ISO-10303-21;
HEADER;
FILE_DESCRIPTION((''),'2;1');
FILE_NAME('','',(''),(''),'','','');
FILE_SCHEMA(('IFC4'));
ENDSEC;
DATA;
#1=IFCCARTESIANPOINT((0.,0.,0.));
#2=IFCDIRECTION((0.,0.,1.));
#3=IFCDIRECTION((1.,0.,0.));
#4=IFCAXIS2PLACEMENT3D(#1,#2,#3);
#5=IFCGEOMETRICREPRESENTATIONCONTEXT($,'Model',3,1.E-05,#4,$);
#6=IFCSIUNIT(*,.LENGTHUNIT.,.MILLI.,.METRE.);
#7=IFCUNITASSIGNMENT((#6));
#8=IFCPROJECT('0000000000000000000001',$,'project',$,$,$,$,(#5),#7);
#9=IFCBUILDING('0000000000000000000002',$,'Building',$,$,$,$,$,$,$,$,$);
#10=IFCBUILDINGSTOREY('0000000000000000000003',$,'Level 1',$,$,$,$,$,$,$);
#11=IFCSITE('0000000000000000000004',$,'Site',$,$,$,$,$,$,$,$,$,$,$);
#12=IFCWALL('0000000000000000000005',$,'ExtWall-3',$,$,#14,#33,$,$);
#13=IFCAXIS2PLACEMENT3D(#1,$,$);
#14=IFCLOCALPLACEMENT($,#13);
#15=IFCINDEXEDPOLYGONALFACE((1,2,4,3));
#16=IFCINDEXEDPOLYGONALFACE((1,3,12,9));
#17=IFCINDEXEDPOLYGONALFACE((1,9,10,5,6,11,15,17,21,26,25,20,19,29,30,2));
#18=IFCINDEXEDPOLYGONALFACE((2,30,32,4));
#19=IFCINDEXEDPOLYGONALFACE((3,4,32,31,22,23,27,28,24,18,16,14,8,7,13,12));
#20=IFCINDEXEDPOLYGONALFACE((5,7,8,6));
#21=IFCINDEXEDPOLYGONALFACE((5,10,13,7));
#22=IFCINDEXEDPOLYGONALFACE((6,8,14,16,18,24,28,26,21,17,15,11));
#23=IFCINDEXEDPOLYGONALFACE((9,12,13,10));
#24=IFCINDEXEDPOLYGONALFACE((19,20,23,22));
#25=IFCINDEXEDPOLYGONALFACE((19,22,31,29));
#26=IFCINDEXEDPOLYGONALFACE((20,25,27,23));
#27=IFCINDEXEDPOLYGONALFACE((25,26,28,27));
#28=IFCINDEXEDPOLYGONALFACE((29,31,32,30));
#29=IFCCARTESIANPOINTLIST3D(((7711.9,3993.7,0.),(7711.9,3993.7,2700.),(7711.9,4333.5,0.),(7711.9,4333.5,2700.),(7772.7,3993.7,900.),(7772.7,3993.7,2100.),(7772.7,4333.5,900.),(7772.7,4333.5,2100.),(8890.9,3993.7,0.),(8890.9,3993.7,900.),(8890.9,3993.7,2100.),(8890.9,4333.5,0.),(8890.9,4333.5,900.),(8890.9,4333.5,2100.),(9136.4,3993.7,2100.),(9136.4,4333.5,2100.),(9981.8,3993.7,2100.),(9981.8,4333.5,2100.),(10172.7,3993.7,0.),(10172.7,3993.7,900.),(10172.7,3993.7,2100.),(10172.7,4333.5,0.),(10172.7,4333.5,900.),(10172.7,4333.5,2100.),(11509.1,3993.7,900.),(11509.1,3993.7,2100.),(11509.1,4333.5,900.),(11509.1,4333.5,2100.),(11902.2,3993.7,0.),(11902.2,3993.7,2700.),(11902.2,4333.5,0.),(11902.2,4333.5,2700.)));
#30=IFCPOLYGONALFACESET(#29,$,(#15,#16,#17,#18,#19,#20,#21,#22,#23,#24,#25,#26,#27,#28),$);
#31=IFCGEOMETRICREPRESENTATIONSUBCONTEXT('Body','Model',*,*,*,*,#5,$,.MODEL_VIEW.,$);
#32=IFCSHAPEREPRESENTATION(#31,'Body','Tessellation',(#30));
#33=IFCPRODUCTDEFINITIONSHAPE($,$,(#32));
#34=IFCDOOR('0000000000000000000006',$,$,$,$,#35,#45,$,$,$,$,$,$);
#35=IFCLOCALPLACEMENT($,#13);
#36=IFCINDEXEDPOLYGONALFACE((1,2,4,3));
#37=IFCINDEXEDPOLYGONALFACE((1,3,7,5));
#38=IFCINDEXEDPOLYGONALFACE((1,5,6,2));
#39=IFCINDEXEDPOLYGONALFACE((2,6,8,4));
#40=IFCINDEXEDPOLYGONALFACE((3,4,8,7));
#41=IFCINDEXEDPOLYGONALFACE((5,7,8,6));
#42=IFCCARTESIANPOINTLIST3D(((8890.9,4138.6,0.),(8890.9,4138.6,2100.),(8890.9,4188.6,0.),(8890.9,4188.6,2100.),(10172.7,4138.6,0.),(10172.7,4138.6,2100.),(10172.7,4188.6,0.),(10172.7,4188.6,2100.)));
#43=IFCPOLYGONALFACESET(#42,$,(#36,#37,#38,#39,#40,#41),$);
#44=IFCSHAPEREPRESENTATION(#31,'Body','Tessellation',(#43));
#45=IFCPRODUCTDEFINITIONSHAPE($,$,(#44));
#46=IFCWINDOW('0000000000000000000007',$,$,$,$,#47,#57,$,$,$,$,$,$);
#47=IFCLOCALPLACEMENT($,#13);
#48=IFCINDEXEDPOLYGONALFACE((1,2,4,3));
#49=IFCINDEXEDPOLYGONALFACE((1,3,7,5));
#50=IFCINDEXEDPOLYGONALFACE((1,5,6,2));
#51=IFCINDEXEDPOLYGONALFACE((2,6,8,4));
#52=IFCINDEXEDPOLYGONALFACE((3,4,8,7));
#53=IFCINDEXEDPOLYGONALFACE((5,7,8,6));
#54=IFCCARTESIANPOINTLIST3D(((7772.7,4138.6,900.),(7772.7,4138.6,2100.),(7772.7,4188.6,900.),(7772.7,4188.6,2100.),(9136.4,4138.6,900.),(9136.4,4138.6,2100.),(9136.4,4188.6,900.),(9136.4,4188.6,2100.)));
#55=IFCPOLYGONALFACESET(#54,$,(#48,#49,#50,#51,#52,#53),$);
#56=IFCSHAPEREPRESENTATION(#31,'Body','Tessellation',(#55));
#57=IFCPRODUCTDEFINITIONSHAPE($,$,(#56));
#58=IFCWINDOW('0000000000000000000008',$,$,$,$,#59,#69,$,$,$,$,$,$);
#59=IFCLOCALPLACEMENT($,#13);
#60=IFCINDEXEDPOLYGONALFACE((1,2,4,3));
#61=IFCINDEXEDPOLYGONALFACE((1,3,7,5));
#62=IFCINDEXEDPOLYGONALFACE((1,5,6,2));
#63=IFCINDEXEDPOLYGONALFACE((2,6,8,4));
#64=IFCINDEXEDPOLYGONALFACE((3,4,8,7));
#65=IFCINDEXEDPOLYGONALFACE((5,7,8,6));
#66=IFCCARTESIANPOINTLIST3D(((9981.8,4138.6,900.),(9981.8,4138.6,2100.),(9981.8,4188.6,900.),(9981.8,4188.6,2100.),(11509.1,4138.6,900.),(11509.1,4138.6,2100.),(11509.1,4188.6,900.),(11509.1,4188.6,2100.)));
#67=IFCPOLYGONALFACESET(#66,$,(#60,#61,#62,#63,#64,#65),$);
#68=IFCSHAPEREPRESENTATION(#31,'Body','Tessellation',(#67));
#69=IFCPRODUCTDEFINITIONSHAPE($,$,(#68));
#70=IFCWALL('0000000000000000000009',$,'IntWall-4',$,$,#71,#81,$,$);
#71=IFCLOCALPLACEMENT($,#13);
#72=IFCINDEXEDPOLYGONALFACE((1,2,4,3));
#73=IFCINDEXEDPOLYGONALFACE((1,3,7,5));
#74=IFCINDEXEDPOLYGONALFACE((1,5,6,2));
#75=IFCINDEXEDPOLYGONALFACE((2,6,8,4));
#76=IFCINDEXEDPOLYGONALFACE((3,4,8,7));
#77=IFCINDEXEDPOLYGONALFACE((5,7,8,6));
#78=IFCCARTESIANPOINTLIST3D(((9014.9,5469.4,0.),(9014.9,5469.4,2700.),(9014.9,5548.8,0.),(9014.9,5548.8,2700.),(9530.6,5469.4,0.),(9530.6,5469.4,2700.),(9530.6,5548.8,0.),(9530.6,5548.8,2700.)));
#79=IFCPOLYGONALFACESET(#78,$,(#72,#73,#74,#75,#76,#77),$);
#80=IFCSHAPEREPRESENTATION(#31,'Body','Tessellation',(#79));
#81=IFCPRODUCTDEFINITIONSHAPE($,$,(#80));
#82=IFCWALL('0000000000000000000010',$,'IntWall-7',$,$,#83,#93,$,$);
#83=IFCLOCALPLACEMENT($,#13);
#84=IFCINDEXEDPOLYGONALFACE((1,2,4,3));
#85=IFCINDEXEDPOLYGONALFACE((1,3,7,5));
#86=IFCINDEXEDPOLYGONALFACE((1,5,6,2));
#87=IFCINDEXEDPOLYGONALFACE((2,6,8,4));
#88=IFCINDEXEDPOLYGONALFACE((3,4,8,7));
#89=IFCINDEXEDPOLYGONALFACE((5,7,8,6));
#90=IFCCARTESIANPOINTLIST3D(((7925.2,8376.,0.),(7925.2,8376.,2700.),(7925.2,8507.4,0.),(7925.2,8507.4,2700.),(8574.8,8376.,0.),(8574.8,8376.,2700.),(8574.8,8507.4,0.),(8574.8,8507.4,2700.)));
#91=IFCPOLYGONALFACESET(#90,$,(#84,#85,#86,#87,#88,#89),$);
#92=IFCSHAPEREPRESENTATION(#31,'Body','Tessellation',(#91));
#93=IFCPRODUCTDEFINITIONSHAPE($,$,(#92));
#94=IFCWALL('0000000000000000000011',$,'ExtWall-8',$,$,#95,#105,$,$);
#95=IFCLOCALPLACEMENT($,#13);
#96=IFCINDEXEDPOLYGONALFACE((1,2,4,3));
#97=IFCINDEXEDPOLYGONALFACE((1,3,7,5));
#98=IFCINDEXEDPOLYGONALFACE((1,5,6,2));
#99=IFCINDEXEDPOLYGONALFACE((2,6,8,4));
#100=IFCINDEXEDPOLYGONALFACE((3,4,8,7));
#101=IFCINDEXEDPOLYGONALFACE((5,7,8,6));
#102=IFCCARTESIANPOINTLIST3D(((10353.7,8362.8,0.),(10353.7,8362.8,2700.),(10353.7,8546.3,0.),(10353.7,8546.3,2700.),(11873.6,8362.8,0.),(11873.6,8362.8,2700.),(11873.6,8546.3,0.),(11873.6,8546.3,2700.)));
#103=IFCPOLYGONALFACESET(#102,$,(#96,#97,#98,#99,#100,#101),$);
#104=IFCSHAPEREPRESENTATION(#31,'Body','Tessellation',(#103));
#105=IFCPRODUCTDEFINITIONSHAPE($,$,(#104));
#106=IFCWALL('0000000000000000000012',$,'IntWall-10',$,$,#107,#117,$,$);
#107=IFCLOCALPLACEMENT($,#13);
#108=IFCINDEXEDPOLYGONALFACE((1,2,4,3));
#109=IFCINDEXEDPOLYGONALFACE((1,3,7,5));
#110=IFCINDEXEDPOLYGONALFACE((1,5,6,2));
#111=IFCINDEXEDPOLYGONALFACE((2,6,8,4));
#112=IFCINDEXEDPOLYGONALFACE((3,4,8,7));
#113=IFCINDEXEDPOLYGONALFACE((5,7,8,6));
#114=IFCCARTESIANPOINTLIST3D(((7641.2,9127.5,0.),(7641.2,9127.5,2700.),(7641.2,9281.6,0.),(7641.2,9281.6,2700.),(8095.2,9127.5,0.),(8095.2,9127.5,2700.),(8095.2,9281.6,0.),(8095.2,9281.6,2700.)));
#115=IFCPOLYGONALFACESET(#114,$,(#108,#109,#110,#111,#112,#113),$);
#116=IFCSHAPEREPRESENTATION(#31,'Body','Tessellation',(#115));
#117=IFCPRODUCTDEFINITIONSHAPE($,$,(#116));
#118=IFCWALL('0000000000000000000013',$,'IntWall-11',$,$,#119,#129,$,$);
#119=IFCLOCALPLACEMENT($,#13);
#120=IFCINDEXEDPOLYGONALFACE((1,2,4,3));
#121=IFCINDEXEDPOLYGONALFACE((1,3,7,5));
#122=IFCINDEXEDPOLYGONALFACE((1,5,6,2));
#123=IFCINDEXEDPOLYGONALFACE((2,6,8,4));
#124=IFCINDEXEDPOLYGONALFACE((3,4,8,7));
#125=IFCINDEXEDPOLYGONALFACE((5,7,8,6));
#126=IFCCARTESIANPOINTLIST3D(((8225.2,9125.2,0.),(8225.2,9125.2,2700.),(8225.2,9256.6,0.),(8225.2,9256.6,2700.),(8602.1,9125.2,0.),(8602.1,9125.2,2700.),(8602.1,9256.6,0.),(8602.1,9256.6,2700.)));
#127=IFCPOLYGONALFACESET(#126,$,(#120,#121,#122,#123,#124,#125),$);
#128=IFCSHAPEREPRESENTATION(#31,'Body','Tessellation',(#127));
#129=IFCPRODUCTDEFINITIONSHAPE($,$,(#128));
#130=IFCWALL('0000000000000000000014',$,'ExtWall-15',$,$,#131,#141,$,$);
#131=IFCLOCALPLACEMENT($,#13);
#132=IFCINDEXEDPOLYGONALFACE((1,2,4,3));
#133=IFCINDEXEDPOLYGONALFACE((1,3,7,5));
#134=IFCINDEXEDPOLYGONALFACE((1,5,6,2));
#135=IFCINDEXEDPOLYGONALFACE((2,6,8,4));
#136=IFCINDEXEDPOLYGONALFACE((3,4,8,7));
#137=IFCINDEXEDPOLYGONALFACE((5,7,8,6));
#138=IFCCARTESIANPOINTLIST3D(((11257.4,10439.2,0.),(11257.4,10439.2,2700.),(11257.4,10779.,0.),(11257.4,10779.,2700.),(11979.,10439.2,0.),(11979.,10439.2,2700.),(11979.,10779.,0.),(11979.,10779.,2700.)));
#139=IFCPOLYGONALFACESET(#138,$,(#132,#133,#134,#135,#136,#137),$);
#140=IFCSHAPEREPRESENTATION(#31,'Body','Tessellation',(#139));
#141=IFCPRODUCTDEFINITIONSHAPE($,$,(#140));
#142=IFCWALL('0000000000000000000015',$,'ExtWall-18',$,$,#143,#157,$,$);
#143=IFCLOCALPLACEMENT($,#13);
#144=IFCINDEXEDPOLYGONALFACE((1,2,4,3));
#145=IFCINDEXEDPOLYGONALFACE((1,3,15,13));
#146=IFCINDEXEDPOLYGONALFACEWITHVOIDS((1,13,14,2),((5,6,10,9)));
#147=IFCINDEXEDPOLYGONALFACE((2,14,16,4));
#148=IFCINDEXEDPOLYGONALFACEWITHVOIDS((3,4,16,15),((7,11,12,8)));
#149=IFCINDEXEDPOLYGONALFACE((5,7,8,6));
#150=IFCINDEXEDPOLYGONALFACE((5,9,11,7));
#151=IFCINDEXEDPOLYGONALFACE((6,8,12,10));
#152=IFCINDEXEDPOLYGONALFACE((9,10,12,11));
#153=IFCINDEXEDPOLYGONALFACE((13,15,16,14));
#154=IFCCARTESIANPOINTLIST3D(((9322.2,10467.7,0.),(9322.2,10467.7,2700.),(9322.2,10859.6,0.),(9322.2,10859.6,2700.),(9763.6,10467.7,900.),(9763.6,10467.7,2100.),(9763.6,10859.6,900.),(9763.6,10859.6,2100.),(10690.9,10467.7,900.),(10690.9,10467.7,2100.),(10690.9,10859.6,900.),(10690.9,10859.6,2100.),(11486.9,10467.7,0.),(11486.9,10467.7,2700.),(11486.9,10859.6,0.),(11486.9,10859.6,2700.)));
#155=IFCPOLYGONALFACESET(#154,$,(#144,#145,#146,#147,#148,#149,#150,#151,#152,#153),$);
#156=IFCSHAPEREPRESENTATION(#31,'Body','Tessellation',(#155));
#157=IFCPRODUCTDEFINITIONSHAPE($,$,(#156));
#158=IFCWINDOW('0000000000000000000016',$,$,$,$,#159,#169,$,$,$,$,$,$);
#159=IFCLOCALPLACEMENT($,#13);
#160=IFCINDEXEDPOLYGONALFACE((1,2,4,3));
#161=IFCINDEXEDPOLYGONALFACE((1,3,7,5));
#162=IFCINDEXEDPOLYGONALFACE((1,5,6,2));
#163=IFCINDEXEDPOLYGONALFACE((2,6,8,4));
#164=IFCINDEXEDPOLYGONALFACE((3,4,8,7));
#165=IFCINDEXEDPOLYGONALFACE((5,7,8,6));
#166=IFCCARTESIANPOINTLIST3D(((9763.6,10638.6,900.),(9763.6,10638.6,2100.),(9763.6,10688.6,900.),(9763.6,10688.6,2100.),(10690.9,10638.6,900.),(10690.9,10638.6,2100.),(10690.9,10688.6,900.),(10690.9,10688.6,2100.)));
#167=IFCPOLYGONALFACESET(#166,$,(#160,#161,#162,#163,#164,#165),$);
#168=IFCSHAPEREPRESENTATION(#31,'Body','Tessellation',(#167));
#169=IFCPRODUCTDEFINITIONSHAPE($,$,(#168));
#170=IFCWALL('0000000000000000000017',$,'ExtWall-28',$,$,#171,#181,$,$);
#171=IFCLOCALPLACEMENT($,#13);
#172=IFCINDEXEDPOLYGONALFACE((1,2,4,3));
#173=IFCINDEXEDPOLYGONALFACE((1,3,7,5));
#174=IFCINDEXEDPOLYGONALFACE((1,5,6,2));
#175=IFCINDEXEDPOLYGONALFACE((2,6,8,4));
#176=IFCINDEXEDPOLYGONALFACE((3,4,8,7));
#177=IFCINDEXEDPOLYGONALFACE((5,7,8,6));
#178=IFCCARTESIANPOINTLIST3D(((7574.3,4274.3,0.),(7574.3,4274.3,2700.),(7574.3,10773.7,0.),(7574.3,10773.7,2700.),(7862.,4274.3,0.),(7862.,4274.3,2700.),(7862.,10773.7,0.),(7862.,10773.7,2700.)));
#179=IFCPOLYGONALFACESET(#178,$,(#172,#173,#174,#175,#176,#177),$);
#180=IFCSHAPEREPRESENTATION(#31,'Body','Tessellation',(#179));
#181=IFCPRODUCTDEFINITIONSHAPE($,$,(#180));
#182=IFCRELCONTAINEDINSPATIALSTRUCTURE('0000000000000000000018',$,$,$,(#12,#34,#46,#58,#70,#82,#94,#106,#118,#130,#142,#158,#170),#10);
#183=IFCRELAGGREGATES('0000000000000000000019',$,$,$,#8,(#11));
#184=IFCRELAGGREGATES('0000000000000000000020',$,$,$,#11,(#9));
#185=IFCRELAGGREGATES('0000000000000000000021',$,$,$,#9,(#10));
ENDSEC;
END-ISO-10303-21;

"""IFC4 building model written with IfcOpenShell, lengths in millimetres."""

from ifc_helpers import new_model, si_unit, frame, origin_with_axes, place, context, subcontext, project, spatial, indexed_curve, outline, extrude, element, fill, save


model = new_model("IFC4")

# Units and contexts
model_context = context("Model", 3, precision=1e-05, world=origin_with_axes())
body_context = subcontext(model_context, "Body", "Model", "MODEL_VIEW")
ifc_project = project(units=[si_unit("LENGTHUNIT", "METRE", prefix="MILLI")], contexts=[model_context])

# Site, building, storey
site = spatial("IfcSite", under=ifc_project, Name="Site")
building = spatial("IfcBuilding", under=site, Name="Building")
storey = spatial("IfcBuildingStorey", under=building, Name="Level 1")

# Wall, openings, door, windows
wall_1_placement = place(None, frame((7711.9, 4163.6, 0.0), z_axis=(0.0, 0.0, 1.0), x_axis=(1.0, 0.0, 0.0)))
wall_1 = element("IfcWall", 1, at=wall_1_placement, inside=storey, Name="ExtWall-3", context=body_context, shape_type="SweptSolid", body=[
    extrude(outline(indexed_curve([(0.0, 0.0), (0.0, 339.8), (4190.3, 339.8), (4190.3, 0.0), (0.0, 0.0)], self_intersect=False)), frame((0.0, -169.9, 0.0), z_axis=(0.0, 0.0, 1.0), x_axis=(1.0, 0.0, 0.0)), (0.0, 0.0, 1.0), 2700.0),
])
opening_1_placement = place(wall_1_placement, frame((1179.0, 0.0, 0.0), z_axis=(0.0, 0.0, 1.0), x_axis=(1.0, 0.0, 0.0)))
opening_1 = element("IfcOpeningElement", 2, at=opening_1_placement, cuts=wall_1, context=body_context, shape_type="SweptSolid", body=[
    extrude(outline(indexed_curve([(0.0, 0.0), (0.0, 439.8), (1281.8, 439.8), (1281.8, 0.0), (0.0, 0.0)], self_intersect=False)), frame((0.0, -219.9, 0.0), z_axis=(0.0, 0.0, 1.0), x_axis=(1.0, 0.0, 0.0)), (0.0, 0.0, 1.0), 2100.0),
])
opening_2_placement = place(wall_1_placement, frame((60.8, 0.0, 900.0), z_axis=(0.0, 0.0, 1.0), x_axis=(1.0, 0.0, 0.0)))
opening_2 = element("IfcOpeningElement", 3, at=opening_2_placement, cuts=wall_1, context=body_context, shape_type="SweptSolid", body=[
    extrude(outline(indexed_curve([(0.0, 0.0), (0.0, 439.8), (1363.6, 439.8), (1363.6, 0.0), (0.0, 0.0)], self_intersect=False)), frame((0.0, -219.9, 0.0), z_axis=(0.0, 0.0, 1.0), x_axis=(1.0, 0.0, 0.0)), (0.0, 0.0, 1.0), 1200.0),
])
opening_3_placement = place(wall_1_placement, frame((2269.9, 0.0, 900.0), z_axis=(0.0, 0.0, 1.0), x_axis=(1.0, 0.0, 0.0)))
opening_3 = element("IfcOpeningElement", 4, at=opening_3_placement, cuts=wall_1, context=body_context, shape_type="SweptSolid", body=[
    extrude(outline(indexed_curve([(0.0, 0.0), (0.0, 439.8), (1527.3, 439.8), (1527.3, 0.0), (0.0, 0.0)], self_intersect=False)), frame((0.0, -219.9, 0.0), z_axis=(0.0, 0.0, 1.0), x_axis=(1.0, 0.0, 0.0)), (0.0, 0.0, 1.0), 1200.0),
])
door_placement = place(opening_1_placement, origin_with_axes())
door = element("IfcDoor", 5, at=door_placement, inside=storey, context=body_context, shape_type="SweptSolid", body=[
    extrude(outline(indexed_curve([(0.0, 0.0), (0.0, 50.0), (1281.8, 50.0), (1281.8, 0.0), (0.0, 0.0)], self_intersect=False)), frame((0.0, -25.0, 0.0), z_axis=(0.0, 0.0, 1.0), x_axis=(1.0, 0.0, 0.0)), (0.0, 0.0, 1.0), 2100.0),
])
fill(opening_1, door)
window_1_placement = place(opening_2_placement, origin_with_axes())
window_1 = element("IfcWindow", 6, at=window_1_placement, inside=storey, context=body_context, shape_type="SweptSolid", body=[
    extrude(outline(indexed_curve([(0.0, 0.0), (0.0, 50.0), (1363.6, 50.0), (1363.6, 0.0), (0.0, 0.0)], self_intersect=False)), frame((0.0, -25.0, 0.0), z_axis=(0.0, 0.0, 1.0), x_axis=(1.0, 0.0, 0.0)), (0.0, 0.0, 1.0), 1200.0),
])
fill(opening_2, window_1)
window_2_placement = place(opening_3_placement, origin_with_axes())
window_2 = element("IfcWindow", 7, at=window_2_placement, inside=storey, context=body_context, shape_type="SweptSolid", body=[
    extrude(outline(indexed_curve([(0.0, 0.0), (0.0, 50.0), (1527.3, 50.0), (1527.3, 0.0), (0.0, 0.0)], self_intersect=False)), frame((0.0, -25.0, 0.0), z_axis=(0.0, 0.0, 1.0), x_axis=(1.0, 0.0, 0.0)), (0.0, 0.0, 1.0), 1200.0),
])
fill(opening_3, window_2)

# Walls
wall_2_placement = place(None, frame((9014.9, 5509.1, 0.0), z_axis=(0.0, 0.0, 1.0), x_axis=(1.0, 0.0, 0.0)))
element("IfcWall", 8, at=wall_2_placement, inside=storey, Name="IntWall-4", context=body_context, shape_type="SweptSolid", body=[
    extrude(outline(indexed_curve([(0.0, 0.0), (0.0, 79.4), (515.7, 79.4), (515.7, 0.0), (0.0, 0.0)], self_intersect=False)), frame((0.0, -39.7, 0.0), z_axis=(0.0, 0.0, 1.0), x_axis=(1.0, 0.0, 0.0)), (0.0, 0.0, 1.0), 2700.0),
])
wall_3_placement = place(None, frame((7925.2, 8441.7, 0.0), z_axis=(0.0, 0.0, 1.0), x_axis=(1.0, 0.0, 0.0)))
element("IfcWall", 9, at=wall_3_placement, inside=storey, Name="IntWall-7", context=body_context, shape_type="SweptSolid", body=[
    extrude(outline(indexed_curve([(0.0, 0.0), (0.0, 131.5), (649.6, 131.5), (649.6, 0.0), (0.0, 0.0)], self_intersect=False)), frame((0.0, -65.7, 0.0), z_axis=(0.0, 0.0, 1.0), x_axis=(1.0, 0.0, 0.0)), (0.0, 0.0, 1.0), 2700.0),
])
wall_4_placement = place(None, frame((10353.7, 8454.5, 0.0), z_axis=(0.0, 0.0, 1.0), x_axis=(1.0, 0.0, 0.0)))
element("IfcWall", 10, at=wall_4_placement, inside=storey, Name="ExtWall-8", context=body_context, shape_type="SweptSolid", body=[
    extrude(outline(indexed_curve([(0.0, 0.0), (0.0, 183.5), (1519.9, 183.5), (1519.9, 0.0), (0.0, 0.0)], self_intersect=False)), frame((0.0, -91.8, 0.0), z_axis=(0.0, 0.0, 1.0), x_axis=(1.0, 0.0, 0.0)), (0.0, 0.0, 1.0), 2700.0),
])
wall_5_placement = place(None, frame((7641.2, 9204.5, 0.0), z_axis=(0.0, 0.0, 1.0), x_axis=(1.0, 0.0, 0.0)))
element("IfcWall", 11, at=wall_5_placement, inside=storey, Name="IntWall-10", context=body_context, shape_type="SweptSolid", body=[
    extrude(outline(indexed_curve([(0.0, 0.0), (0.0, 154.1), (454.1, 154.1), (454.1, 0.0), (0.0, 0.0)], self_intersect=False)), frame((0.0, -77.0, 0.0), z_axis=(0.0, 0.0, 1.0), x_axis=(1.0, 0.0, 0.0)), (0.0, 0.0, 1.0), 2700.0),
])
wall_6_placement = place(None, frame((8225.2, 9190.9, 0.0), z_axis=(0.0, 0.0, 1.0), x_axis=(1.0, 0.0, 0.0)))
element("IfcWall", 12, at=wall_6_placement, inside=storey, Name="IntWall-11", context=body_context, shape_type="SweptSolid", body=[
    extrude(outline(indexed_curve([(0.0, 0.0), (0.0, 131.5), (376.9, 131.5), (376.9, 0.0), (0.0, 0.0)], self_intersect=False)), frame((0.0, -65.7, 0.0), z_axis=(0.0, 0.0, 1.0), x_axis=(1.0, 0.0, 0.0)), (0.0, 0.0, 1.0), 2700.0),
])
wall_7_placement = place(None, frame((11257.4, 10609.1, 0.0), z_axis=(0.0, 0.0, 1.0), x_axis=(1.0, 0.0, 0.0)))
element("IfcWall", 13, at=wall_7_placement, inside=storey, Name="ExtWall-15", context=body_context, shape_type="SweptSolid", body=[
    extrude(outline(indexed_curve([(0.0, 0.0), (0.0, 339.8), (721.6, 339.8), (721.6, 0.0), (0.0, 0.0)], self_intersect=False)), frame((0.0, -169.9, 0.0), z_axis=(0.0, 0.0, 1.0), x_axis=(1.0, 0.0, 0.0)), (0.0, 0.0, 1.0), 2700.0),
])

# Wall, opening, window
wall_8_placement = place(None, frame((9322.2, 10663.6, 0.0), z_axis=(0.0, 0.0, 1.0), x_axis=(1.0, 0.0, 0.0)))
wall_8 = element("IfcWall", 14, at=wall_8_placement, inside=storey, Name="ExtWall-18", context=body_context, shape_type="SweptSolid", body=[
    extrude(outline(indexed_curve([(0.0, 0.0), (0.0, 391.9), (2164.6, 391.9), (2164.6, 0.0), (0.0, 0.0)], self_intersect=False)), frame((0.0, -196.0, 0.0), z_axis=(0.0, 0.0, 1.0), x_axis=(1.0, 0.0, 0.0)), (0.0, 0.0, 1.0), 2700.0),
])
opening_4_placement = place(wall_8_placement, frame((441.4, 0.0, 900.0), z_axis=(0.0, 0.0, 1.0), x_axis=(1.0, 0.0, 0.0)))
opening_4 = element("IfcOpeningElement", 15, at=opening_4_placement, cuts=wall_8, context=body_context, shape_type="SweptSolid", body=[
    extrude(outline(indexed_curve([(0.0, 0.0), (0.0, 491.9), (927.3, 491.9), (927.3, 0.0), (0.0, 0.0)], self_intersect=False)), frame((0.0, -246.0, 0.0), z_axis=(0.0, 0.0, 1.0), x_axis=(1.0, 0.0, 0.0)), (0.0, 0.0, 1.0), 1200.0),
])
window_3_placement = place(opening_4_placement, frame((0.0, 0.0, 0.0), z_axis=(0.0, 0.0, 1.0), x_axis=(1.0, 0.0, 0.0)))
window_3 = element("IfcWindow", 16, at=window_3_placement, inside=storey, context=body_context, shape_type="SweptSolid", body=[
    extrude(outline(indexed_curve([(0.0, 0.0), (0.0, 50.0), (927.3, 50.0), (927.3, 0.0), (0.0, 0.0)], self_intersect=False)), frame((0.0, -25.0, 0.0), z_axis=(0.0, 0.0, 1.0), x_axis=(1.0, 0.0, 0.0)), (0.0, 0.0, 1.0), 1200.0),
])
fill(opening_4, window_3)

# Wall
wall_9_placement = place(None, frame((7718.2, 4274.3, 0.0), z_axis=(0.0, 0.0, 1.0), x_axis=(0.0, 1.0, 0.0)))
element("IfcWall", 17, at=wall_9_placement, inside=storey, Name="ExtWall-28", context=body_context, shape_type="SweptSolid", body=[
    extrude(outline(indexed_curve([(0.0, 0.0), (0.0, 287.7), (6499.4, 287.7), (6499.4, 0.0), (0.0, 0.0)], self_intersect=False)), frame((0.0, -143.9, 0.0), z_axis=(0.0, 0.0, 1.0), x_axis=(1.0, 0.0, 0.0)), (0.0, 0.0, 1.0), 2700.0),
])

save(model, "model.ifc")
